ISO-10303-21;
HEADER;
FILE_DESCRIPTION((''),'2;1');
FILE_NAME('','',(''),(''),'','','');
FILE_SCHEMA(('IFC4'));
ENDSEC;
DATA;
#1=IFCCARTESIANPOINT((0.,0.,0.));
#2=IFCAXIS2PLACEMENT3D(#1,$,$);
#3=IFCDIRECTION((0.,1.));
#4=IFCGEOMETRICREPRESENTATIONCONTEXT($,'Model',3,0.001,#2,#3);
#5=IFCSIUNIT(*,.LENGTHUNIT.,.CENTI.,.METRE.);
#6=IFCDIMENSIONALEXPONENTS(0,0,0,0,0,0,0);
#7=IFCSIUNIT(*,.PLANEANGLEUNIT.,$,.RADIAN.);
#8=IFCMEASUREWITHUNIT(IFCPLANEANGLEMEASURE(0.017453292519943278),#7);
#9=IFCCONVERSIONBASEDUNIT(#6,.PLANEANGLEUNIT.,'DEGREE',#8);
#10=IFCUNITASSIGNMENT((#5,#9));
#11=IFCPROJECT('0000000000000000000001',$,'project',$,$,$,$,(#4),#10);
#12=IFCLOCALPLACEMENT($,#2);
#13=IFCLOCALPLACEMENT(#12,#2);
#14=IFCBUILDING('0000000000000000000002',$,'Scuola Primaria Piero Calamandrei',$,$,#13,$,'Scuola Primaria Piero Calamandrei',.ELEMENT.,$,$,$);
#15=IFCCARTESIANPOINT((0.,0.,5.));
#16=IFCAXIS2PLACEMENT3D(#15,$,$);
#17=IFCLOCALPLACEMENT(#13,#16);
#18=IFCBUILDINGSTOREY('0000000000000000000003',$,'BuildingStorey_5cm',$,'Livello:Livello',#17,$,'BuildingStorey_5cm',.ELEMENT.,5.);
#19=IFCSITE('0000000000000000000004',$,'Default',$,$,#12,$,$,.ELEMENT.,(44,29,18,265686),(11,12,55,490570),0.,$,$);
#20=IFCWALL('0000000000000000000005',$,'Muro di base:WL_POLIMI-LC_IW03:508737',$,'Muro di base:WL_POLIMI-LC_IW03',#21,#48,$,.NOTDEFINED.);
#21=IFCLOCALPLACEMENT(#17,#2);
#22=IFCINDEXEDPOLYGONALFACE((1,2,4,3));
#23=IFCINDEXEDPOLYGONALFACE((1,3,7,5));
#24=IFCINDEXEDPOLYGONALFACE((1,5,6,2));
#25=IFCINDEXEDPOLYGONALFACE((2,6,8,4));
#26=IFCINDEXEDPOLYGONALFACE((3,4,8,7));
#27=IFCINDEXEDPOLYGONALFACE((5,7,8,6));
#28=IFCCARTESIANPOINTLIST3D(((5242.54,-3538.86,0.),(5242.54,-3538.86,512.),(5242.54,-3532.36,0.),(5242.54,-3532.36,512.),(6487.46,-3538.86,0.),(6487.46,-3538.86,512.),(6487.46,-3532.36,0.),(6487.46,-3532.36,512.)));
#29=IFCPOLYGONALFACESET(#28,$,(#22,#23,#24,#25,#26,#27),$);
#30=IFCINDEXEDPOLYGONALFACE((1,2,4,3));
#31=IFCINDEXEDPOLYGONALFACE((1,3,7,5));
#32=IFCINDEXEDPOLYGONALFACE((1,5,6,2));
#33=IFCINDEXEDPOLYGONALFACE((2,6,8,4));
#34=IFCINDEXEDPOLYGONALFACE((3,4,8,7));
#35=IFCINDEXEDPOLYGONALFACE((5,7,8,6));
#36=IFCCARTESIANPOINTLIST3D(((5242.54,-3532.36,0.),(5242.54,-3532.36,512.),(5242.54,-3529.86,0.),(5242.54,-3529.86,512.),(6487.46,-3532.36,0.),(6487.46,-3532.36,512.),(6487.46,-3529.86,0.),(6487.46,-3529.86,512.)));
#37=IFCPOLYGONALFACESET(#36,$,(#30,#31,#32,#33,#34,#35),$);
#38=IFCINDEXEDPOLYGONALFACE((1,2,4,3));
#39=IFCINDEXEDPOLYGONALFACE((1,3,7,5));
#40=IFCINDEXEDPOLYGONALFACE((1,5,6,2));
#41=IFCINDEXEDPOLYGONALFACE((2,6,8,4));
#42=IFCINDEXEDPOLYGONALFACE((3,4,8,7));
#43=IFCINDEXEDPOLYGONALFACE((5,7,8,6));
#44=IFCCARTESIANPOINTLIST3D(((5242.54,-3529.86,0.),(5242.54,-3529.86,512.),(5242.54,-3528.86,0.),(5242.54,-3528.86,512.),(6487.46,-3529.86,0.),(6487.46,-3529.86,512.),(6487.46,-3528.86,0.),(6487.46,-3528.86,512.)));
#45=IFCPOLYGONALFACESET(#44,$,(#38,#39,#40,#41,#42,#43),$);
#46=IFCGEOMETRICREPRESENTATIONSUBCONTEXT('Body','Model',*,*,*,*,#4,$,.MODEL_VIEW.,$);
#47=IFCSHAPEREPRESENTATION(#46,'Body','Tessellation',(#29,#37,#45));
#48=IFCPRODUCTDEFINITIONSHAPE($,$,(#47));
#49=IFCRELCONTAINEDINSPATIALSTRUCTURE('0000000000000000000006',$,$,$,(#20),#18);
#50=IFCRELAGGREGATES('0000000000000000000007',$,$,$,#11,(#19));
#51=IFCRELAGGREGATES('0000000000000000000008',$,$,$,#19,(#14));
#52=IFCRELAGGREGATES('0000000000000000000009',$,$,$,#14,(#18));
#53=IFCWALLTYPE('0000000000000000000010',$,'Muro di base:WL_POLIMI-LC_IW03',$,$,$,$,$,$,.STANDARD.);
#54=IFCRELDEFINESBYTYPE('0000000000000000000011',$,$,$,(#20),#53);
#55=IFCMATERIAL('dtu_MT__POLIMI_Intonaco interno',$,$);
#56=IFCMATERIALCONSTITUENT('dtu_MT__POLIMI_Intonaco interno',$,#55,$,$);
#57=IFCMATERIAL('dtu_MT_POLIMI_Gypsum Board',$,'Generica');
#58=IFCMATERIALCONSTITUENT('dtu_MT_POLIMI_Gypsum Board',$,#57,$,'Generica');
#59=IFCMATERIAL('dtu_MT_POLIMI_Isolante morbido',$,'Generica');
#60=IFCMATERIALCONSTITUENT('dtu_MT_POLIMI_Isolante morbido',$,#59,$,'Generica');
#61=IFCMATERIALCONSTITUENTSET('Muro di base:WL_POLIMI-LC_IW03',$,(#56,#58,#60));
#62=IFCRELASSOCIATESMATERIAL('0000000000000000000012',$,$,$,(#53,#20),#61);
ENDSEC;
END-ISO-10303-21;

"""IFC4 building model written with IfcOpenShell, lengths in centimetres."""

from ifc_helpers import new_model, entity, si_unit, converted_unit, direction, frame, origin, place, context, subcontext, project, spatial, indexed_curve, outline, extrude, material, constituent, constituent_set, type_object, element, save


model = new_model("IFC4")

# Units and contexts
model_context = context("Model", 3, precision=0.001, world=origin(), true_north=direction((0.0, 1.0)))
body_context = subcontext(model_context, "Body", "Model", "MODEL_VIEW")
ifc_project = project(units=[si_unit("LENGTHUNIT", "METRE", prefix="CENTI"), converted_unit("PLANEANGLEUNIT", "DEGREE", entity("IfcPlaneAngleMeasure", 0.017453292519943278), si_unit("PLANEANGLEUNIT", "RADIAN"), dimensions=[0, 0, 0, 0, 0, 0, 0])], contexts=[model_context])

# Site, building, storey
site_placement = place(None, origin())
site = spatial("IfcSite", under=ifc_project, at=site_placement, Name="Default", CompositionType="ELEMENT", RefLatitude=(44, 29, 18, 265686), RefLongitude=(11, 12, 55, 490570), RefElevation=0.0)
building_placement = place(site_placement, origin())
building = spatial("IfcBuilding", under=site, at=building_placement, Name="Scuola Primaria Piero Calamandrei", LongName="Scuola Primaria Piero Calamandrei", CompositionType="ELEMENT")
storey_placement = place(building_placement, frame((0.0, 0.0, 5.0)))
storey = spatial("IfcBuildingStorey", under=building, at=storey_placement, Name="BuildingStorey_5cm", ObjectType="Livello:Livello", LongName="BuildingStorey_5cm", CompositionType="ELEMENT", Elevation=5.0)

# Shared definitions
ifc_material_1 = material(Name="dtu_MT_POLIMI_Isolante morbido", Category="Generica")
ifc_material_2 = material(Name="dtu_MT_POLIMI_Gypsum Board", Category="Generica")
ifc_material_3 = material(Name="dtu_MT__POLIMI_Intonaco interno")

# Wall
ifc_constituent_1 = constituent(ifc_material_3, Name="dtu_MT__POLIMI_Intonaco interno")
ifc_constituent_2 = constituent(ifc_material_2, Name="dtu_MT_POLIMI_Gypsum Board", Category="Generica")
ifc_constituent_3 = constituent(ifc_material_1, Name="dtu_MT_POLIMI_Isolante morbido", Category="Generica")
ifc_constituent_set_1 = constituent_set(constituents=[ifc_constituent_1, ifc_constituent_2, ifc_constituent_3], Name="Muro di base:WL_POLIMI-LC_IW03")
wall_type_1 = type_object("IfcWallType", Name="Muro di base:WL_POLIMI-LC_IW03", PredefinedType="STANDARD", material=ifc_constituent_set_1)
wall_1_placement = place(storey_placement, frame((5242.54, -3533.86, 0.0)))
element("IfcWall", 1, at=wall_1_placement, inside=storey, type_object=wall_type_1, material=ifc_constituent_set_1, Name="Muro di base:WL_POLIMI-LC_IW03:508737", ObjectType="Muro di base:WL_POLIMI-LC_IW03", PredefinedType="NOTDEFINED", context=body_context, shape_type="SweptSolid", body=[
    extrude(outline(indexed_curve([(-3.25, -622.46), (3.25, -622.46), (3.25, 622.46), (-3.25, 622.46), (-3.25, -622.46)], self_intersect=False)), frame((622.46, -1.75, 0.0), z_axis=(0.0, 0.0, 1.0), x_axis=(0.0, 1.0, 0.0)), (0.0, 0.0, 1.0), 512.0),
    extrude(outline(indexed_curve([(-622.46, -1.25), (622.46, -1.25), (622.46, 1.25), (-622.46, 1.25), (-622.46, -1.25)], self_intersect=False)), frame((622.46, 2.75, 0.0)), (0.0, 0.0, 1.0), 512.0),
    extrude(outline(indexed_curve([(-0.5, -622.46), (0.5, -622.46), (0.5, 622.46), (-0.5, 622.46), (-0.5, -622.46)], self_intersect=False)), frame((622.46, 4.5, 0.0), z_axis=(0.0, 0.0, 1.0), x_axis=(0.0, -1.0, 0.0)), (0.0, 0.0, 1.0), 512.0),
])

save(model, "model.ifc")
